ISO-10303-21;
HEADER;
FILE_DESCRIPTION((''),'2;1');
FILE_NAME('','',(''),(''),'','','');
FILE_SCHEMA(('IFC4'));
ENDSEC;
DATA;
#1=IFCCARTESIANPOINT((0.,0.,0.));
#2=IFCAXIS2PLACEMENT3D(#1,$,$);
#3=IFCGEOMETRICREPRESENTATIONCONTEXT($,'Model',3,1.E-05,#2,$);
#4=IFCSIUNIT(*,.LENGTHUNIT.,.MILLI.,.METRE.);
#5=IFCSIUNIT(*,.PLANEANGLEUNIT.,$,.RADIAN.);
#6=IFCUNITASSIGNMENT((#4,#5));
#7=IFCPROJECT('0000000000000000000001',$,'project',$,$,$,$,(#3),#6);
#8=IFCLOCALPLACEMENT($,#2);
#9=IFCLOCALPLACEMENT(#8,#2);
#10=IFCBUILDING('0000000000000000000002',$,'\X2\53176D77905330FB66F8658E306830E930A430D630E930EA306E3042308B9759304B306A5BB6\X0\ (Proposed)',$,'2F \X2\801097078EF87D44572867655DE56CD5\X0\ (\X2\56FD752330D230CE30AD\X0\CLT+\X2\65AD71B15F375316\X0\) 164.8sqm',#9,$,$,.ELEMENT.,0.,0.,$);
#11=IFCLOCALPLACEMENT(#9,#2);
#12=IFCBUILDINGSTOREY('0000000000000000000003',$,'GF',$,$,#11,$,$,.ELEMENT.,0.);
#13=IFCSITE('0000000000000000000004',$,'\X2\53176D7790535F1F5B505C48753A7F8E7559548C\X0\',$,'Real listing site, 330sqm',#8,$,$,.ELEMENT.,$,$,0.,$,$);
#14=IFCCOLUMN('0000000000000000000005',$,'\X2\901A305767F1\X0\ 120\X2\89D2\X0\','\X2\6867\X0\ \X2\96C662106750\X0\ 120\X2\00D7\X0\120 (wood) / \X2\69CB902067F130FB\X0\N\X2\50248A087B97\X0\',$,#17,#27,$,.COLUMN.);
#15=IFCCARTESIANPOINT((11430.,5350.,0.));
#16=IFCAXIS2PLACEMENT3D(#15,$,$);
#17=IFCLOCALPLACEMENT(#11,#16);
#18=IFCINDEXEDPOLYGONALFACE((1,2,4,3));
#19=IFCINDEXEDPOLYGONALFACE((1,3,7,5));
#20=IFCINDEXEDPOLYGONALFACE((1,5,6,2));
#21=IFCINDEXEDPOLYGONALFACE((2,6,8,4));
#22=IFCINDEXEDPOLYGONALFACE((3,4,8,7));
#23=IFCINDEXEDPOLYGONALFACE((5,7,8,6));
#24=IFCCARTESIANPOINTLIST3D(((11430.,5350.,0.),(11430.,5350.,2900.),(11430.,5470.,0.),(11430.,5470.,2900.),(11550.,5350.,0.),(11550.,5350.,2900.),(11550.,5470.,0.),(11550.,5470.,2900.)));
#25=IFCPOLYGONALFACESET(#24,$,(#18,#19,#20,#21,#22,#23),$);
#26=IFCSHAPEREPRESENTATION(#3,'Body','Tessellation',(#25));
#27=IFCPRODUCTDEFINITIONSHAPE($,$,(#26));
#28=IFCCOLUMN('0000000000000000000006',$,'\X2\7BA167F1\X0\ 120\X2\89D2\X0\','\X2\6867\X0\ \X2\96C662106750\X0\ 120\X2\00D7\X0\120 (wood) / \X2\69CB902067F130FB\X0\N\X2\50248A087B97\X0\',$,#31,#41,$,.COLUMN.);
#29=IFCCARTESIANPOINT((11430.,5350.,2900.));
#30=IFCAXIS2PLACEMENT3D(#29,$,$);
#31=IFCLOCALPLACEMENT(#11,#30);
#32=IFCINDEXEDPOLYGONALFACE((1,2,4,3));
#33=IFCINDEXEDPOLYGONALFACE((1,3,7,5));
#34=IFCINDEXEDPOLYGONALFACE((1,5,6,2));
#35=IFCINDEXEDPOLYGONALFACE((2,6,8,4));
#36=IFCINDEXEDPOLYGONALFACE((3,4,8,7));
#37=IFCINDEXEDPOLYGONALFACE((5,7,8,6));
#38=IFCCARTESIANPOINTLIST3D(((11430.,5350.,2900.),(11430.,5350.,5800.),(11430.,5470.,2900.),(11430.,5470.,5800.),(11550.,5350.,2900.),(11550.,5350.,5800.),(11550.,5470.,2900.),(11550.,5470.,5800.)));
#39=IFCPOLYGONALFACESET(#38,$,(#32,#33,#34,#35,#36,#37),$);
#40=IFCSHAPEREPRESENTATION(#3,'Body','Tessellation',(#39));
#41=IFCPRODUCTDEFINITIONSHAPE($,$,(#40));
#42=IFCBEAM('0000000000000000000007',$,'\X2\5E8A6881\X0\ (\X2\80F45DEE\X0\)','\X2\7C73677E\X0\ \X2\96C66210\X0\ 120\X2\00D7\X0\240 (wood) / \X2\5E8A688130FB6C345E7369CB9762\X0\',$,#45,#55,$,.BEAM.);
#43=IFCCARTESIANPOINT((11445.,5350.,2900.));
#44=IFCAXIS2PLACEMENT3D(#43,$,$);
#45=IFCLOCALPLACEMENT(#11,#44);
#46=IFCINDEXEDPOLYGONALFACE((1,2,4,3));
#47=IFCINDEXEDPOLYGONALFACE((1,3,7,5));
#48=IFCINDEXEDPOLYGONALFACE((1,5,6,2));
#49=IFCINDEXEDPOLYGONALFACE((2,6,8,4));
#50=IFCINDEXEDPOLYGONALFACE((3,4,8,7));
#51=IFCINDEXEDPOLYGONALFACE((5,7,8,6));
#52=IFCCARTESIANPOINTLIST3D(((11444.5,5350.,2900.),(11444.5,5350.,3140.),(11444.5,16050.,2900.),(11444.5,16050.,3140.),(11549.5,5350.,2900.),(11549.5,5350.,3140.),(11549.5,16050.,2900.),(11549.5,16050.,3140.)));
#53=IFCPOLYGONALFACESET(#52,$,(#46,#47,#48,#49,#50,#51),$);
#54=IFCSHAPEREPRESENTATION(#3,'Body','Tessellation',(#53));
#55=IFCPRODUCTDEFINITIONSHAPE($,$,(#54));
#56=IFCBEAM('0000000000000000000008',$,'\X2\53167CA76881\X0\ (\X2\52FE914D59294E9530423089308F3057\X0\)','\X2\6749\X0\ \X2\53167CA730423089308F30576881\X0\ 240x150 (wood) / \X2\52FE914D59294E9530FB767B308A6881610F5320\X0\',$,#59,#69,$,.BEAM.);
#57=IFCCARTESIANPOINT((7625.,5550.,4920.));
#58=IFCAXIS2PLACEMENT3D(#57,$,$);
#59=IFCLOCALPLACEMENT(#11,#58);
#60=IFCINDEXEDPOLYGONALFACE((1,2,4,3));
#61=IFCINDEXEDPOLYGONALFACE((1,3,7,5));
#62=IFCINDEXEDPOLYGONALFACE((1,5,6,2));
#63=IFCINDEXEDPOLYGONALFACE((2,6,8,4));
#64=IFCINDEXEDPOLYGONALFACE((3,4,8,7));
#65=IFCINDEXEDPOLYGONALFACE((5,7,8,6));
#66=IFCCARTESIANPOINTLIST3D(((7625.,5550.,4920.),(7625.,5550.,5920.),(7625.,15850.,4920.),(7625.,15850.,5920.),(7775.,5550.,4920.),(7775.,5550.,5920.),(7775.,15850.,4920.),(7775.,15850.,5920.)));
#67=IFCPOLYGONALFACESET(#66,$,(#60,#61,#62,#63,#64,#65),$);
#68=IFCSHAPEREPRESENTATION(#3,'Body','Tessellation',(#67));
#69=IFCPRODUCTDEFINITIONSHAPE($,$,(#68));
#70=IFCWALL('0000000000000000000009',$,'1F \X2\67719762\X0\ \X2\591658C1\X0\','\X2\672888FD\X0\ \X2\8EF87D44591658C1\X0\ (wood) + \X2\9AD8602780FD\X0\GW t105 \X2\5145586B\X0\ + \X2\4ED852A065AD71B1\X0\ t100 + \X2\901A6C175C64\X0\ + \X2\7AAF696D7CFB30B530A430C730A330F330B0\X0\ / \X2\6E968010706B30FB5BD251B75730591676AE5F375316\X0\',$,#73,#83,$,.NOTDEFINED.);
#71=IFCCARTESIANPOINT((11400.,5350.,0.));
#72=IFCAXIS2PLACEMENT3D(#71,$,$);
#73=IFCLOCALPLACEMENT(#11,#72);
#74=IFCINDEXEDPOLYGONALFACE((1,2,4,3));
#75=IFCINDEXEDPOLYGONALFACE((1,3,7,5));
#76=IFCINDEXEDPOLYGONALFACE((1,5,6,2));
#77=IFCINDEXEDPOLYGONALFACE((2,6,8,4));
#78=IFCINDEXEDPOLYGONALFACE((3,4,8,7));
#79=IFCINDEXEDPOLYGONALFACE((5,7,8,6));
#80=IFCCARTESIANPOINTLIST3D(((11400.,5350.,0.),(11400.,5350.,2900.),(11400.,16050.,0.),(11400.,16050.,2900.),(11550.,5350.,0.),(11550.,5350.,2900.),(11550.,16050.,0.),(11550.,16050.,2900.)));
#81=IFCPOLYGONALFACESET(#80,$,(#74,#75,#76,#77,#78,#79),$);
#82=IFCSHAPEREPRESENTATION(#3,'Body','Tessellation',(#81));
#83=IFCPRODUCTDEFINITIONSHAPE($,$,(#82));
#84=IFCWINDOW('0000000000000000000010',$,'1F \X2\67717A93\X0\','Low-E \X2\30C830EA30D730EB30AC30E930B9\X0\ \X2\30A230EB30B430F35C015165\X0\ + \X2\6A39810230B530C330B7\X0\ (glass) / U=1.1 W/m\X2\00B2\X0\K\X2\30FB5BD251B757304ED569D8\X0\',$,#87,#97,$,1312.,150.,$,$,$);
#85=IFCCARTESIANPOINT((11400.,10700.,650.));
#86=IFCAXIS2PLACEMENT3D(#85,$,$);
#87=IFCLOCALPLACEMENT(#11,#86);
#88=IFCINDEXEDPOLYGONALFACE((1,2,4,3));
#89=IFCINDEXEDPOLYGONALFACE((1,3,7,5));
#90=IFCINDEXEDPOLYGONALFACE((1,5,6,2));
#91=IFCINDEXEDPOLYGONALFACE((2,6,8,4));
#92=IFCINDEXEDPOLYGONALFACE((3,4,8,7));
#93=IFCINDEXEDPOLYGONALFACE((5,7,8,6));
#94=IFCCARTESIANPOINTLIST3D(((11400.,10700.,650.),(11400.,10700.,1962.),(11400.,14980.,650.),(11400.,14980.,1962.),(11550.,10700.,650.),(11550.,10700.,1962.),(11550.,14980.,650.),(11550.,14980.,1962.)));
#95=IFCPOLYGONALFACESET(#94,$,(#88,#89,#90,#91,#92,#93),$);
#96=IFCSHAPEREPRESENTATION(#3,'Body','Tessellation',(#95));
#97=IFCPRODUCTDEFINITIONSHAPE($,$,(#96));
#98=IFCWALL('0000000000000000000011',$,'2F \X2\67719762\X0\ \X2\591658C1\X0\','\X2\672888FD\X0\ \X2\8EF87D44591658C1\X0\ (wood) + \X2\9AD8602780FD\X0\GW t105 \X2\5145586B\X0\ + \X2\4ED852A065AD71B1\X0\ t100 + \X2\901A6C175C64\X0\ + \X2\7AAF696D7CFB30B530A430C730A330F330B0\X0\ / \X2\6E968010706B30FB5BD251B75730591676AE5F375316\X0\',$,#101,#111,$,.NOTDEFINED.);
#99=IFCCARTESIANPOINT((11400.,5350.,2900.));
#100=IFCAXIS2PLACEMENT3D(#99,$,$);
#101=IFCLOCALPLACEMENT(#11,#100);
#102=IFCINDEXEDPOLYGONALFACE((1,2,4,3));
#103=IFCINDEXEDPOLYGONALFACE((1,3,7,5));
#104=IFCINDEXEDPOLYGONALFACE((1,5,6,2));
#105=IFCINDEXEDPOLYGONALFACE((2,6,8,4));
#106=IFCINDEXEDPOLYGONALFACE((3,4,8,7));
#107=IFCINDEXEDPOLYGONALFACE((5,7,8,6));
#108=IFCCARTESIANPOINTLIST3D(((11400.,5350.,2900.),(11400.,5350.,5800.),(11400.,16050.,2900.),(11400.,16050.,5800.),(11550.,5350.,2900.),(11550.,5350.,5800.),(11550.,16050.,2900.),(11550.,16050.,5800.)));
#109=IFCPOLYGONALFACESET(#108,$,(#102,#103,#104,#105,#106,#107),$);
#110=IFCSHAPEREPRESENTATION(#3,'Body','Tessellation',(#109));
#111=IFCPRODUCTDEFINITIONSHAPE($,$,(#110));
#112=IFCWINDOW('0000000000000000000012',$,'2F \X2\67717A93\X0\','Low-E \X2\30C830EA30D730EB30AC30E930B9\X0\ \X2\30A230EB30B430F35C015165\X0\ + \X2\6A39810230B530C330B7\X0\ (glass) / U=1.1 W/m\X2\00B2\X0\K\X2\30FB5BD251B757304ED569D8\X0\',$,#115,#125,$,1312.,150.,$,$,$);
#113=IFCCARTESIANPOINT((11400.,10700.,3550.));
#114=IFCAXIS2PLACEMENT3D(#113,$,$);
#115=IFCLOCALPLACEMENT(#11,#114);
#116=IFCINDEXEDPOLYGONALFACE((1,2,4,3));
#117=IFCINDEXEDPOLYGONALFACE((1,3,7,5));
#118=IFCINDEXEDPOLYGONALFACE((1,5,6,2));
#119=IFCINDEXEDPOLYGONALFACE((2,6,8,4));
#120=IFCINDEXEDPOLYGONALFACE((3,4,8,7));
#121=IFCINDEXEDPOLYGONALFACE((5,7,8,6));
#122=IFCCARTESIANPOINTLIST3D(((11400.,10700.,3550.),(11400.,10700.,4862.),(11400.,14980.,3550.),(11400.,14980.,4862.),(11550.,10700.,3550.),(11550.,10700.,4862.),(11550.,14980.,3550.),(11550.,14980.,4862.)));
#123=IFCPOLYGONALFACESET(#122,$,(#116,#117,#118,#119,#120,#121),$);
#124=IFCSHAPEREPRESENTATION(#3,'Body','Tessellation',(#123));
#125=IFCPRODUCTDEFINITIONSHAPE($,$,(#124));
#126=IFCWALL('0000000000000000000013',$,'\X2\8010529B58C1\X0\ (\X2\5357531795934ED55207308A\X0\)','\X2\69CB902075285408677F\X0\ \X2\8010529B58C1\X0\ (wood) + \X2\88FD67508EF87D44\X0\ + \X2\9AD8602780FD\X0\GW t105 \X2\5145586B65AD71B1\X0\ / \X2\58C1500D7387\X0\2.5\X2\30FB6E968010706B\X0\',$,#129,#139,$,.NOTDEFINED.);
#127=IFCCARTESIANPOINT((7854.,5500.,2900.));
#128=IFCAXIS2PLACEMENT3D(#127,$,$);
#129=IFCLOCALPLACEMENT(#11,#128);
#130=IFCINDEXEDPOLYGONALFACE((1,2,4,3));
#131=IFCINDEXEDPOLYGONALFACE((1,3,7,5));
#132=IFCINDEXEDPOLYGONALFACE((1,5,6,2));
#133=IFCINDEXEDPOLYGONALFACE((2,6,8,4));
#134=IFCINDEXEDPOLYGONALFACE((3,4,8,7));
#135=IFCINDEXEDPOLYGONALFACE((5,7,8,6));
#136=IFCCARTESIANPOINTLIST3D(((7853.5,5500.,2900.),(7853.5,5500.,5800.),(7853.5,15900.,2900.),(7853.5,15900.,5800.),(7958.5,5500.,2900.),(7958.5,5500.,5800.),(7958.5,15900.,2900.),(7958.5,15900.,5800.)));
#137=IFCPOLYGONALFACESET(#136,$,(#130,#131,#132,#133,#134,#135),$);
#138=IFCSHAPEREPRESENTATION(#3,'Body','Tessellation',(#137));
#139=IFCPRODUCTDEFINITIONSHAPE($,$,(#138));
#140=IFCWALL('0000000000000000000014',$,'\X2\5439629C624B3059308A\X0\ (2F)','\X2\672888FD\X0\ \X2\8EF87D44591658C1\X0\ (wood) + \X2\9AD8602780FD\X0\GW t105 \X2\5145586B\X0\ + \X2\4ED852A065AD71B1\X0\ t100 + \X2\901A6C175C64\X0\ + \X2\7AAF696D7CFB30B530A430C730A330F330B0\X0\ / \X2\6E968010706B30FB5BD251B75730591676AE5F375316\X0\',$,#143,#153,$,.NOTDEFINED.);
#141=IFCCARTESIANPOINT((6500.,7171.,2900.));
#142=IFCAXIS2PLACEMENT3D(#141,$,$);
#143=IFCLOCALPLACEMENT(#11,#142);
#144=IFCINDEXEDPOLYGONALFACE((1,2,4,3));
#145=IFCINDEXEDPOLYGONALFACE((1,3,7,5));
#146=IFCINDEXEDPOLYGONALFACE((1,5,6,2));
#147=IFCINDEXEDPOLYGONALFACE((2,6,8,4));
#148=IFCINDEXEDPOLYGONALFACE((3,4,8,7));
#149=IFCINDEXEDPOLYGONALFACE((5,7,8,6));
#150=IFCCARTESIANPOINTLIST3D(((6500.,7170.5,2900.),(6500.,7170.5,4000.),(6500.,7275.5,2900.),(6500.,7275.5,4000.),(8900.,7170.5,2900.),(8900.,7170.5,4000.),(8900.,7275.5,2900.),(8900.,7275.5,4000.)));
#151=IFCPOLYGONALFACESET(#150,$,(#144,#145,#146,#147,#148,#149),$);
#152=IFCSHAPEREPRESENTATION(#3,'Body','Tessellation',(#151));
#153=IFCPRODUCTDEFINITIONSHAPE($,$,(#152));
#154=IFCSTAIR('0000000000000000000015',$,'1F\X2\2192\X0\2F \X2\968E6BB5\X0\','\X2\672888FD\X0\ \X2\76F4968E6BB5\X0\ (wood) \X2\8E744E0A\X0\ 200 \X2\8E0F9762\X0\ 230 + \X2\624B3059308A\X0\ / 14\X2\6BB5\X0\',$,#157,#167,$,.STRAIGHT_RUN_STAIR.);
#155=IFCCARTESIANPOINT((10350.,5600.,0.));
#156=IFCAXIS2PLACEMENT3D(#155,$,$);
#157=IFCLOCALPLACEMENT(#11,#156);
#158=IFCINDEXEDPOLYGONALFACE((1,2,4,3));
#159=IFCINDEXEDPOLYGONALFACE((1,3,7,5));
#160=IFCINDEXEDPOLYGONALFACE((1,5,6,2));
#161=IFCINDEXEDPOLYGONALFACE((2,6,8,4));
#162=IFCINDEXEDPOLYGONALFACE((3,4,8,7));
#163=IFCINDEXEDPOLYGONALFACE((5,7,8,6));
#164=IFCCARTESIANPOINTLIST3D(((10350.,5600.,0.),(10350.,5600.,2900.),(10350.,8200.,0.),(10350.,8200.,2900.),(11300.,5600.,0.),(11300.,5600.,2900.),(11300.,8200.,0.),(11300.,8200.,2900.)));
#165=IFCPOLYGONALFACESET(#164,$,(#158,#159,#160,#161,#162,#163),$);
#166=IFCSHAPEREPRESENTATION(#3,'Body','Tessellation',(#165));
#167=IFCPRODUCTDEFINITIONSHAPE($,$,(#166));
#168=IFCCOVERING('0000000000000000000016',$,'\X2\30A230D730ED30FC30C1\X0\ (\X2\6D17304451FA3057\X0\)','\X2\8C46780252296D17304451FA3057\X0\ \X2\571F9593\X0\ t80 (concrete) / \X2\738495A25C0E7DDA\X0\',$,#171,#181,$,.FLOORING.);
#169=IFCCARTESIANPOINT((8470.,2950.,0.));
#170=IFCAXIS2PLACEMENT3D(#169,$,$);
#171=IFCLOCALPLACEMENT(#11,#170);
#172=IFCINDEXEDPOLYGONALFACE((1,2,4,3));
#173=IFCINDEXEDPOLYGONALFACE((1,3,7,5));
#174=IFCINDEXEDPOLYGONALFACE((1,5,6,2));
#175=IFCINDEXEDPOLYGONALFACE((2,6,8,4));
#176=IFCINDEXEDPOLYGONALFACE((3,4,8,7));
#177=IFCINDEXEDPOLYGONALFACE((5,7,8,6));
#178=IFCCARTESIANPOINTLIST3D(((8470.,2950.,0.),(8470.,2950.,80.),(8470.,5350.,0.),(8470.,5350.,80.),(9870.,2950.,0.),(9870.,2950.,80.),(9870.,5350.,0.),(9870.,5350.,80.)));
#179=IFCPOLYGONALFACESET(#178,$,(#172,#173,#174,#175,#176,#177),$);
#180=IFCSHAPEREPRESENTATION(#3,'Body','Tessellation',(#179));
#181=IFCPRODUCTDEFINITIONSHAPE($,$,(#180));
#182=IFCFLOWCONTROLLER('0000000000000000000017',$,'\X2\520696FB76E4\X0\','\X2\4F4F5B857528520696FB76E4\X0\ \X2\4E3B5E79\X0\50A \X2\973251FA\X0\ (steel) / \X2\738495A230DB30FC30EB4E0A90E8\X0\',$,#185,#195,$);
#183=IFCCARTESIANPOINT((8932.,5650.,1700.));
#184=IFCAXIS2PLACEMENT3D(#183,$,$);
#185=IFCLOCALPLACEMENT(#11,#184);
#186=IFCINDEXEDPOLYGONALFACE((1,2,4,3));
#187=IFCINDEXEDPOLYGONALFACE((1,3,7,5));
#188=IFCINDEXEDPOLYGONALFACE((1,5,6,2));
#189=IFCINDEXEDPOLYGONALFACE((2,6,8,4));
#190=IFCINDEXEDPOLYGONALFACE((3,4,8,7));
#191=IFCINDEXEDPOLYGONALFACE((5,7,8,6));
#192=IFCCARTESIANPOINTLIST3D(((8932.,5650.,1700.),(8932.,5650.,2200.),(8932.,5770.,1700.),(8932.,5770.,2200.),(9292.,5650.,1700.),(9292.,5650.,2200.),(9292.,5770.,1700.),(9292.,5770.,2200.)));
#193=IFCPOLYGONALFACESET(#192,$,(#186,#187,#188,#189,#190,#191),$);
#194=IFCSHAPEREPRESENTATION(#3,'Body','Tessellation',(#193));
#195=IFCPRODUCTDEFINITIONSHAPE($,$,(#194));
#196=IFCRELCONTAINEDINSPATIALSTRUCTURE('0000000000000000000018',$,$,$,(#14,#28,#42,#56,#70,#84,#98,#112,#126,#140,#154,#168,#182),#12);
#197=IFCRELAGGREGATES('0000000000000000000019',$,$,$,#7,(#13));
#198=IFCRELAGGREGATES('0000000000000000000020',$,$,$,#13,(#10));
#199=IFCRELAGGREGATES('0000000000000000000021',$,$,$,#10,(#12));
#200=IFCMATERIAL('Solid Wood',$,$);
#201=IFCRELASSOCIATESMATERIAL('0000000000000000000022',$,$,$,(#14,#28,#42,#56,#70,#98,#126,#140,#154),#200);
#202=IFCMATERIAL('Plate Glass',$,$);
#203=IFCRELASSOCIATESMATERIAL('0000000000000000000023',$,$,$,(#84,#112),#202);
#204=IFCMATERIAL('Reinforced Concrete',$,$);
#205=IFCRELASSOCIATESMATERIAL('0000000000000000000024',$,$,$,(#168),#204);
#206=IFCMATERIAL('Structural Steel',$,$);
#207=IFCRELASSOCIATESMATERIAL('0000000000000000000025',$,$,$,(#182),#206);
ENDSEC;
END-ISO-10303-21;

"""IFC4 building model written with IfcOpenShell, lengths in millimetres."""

from ifc_helpers import new_model, si_unit, frame, frame_2d, origin, place, context, project, spatial, rectangle, extrude, material, element, fill, save


model = new_model("IFC4")

# Units and contexts
model_context = context("Model", 3, precision=1e-05, world=origin())
ifc_project = project(units=[si_unit("LENGTHUNIT", "METRE", prefix="MILLI"), si_unit("PLANEANGLEUNIT", "RADIAN")], contexts=[model_context])

# Site, building, storey
site_placement = place(None, origin())
site = spatial("IfcSite", under=ifc_project, at=site_placement, Name="北海道弟子屈町美留和", ObjectType="Real listing site, 330sqm", CompositionType="ELEMENT", RefElevation=0.0)
building_placement = place(site_placement, origin())
building = spatial("IfcBuilding", under=site, at=building_placement, Name="北海道・書斎とライブラリのある静かな家 (Proposed)", ObjectType="2F 耐震軸組在来工法 (国産ヒノキCLT+断熱強化) 164.8sqm", CompositionType="ELEMENT", ElevationOfRefHeight=0.0, ElevationOfTerrain=0.0)
storey_placement = place(building_placement, origin())
storey = spatial("IfcBuildingStorey", under=building, at=storey_placement, Name="GF", CompositionType="ELEMENT", Elevation=0.0)

# Columns
ifc_material_1 = material(Name="Solid Wood")
column_1_placement = place(storey_placement, frame((11430.0, 5350.0, 0.0)))
element("IfcColumn", 1, at=column_1_placement, inside=storey, material=ifc_material_1, Name="通し柱 120角", Description="桧 集成材 120×120 (wood) / 構造柱・N値計算", PredefinedType="COLUMN", context=model_context, shape_type="SweptSolid", body=[
    extrude(rectangle(XDim=120.0, YDim=120.0, at=frame_2d((60.0, 60.0))), frame((11430.0, 5350.0, 0.0)), (0.0, 0.0, 1.0), 2900.0),
])
column_2_placement = place(storey_placement, frame((11430.0, 5350.0, 2900.0)))
element("IfcColumn", 2, at=column_2_placement, inside=storey, material=ifc_material_1, Name="管柱 120角", Description="桧 集成材 120×120 (wood) / 構造柱・N値計算", PredefinedType="COLUMN", context=model_context, shape_type="SweptSolid", body=[
    extrude(rectangle(XDim=120.0, YDim=120.0, at=frame_2d((60.0, 60.0))), frame((11430.0, 5350.0, 2900.0)), (0.0, 0.0, 1.0), 2900.0),
])

# Beams
beam_1_placement = place(storey_placement, frame((11445.0, 5350.0, 2900.0)))
element("IfcBeam", 3, at=beam_1_placement, inside=storey, material=ifc_material_1, Name="床梁 (胴差)", Description="米松 集成 120×240 (wood) / 床梁・水平構面", PredefinedType="BEAM", context=model_context, shape_type="SweptSolid", body=[
    extrude(rectangle(XDim=105.0, YDim=10700.0, at=frame_2d((52.0, 5350.0))), frame((11445.0, 5350.0, 2900.0)), (0.0, 0.0, 1.0), 240.0),
])
beam_2_placement = place(storey_placement, frame((7625.0, 5550.0, 4920.0)))
element("IfcBeam", 4, at=beam_2_placement, inside=storey, material=ifc_material_1, Name="化粧梁 (勾配天井あらわし)", Description="杉 化粧あらわし梁 240x150 (wood) / 勾配天井・登り梁意匠", PredefinedType="BEAM", context=model_context, shape_type="SweptSolid", body=[
    extrude(rectangle(XDim=150.0, YDim=10300.0, at=frame_2d((75.0, 5150.0))), frame((7625.0, 5550.0, 4920.0)), (0.0, 0.0, 1.0), 1000.0),
])

# Wall, opening, window
wall_1_placement = place(storey_placement, frame((11400.0, 5350.0, 0.0)))
wall_1 = element("IfcWall", 5, at=wall_1_placement, inside=storey, material=ifc_material_1, Name="1F 東面 外壁", Description="木製 軸組外壁 (wood) + 高性能GW t105 充填 + 付加断熱 t100 + 通気層 + 窯業系サイディング / 準耐火・寒冷地外皮強化", PredefinedType="NOTDEFINED", context=model_context, shape_type="SweptSolid", body=[
    extrude(rectangle(XDim=150.0, YDim=10700.0, at=frame_2d((75.0, 5350.0))), frame((11400.0, 5350.0, 0.0)), (0.0, 0.0, 1.0), 2900.0),
])
opening_1_placement = place(storey_placement, frame((11400.0, 10700.0, 650.0)))
opening_1 = element("IfcOpeningElement", 6, at=opening_1_placement, cuts=wall_1, PredefinedType="NOTDEFINED", context=model_context, shape_type="SweptSolid", body=[
    extrude(rectangle(XDim=150.0, YDim=4280.0, at=frame_2d((75.0, 2140.0))), frame((11400.0, 10700.0, 650.0)), (0.0, 0.0, 1.0), 1312.0),
])
ifc_material_2 = material(Name="Plate Glass")
window_1_placement = place(storey_placement, frame((11400.0, 10700.0, 650.0)))
window_1 = element("IfcWindow", 7, at=window_1_placement, inside=storey, material=ifc_material_2, Name="1F 東窓", Description="Low-E トリプルガラス アルゴン封入 + 樹脂サッシ (glass) / U=1.1 W/m²K・寒冷地仕様", OverallHeight=1312.0, OverallWidth=150.0, context=model_context, shape_type="SweptSolid", body=[
    extrude(rectangle(XDim=150.0, YDim=4280.0, at=frame_2d((75.0, 2140.0))), frame((11400.0, 10700.0, 650.0)), (0.0, 0.0, 1.0), 1312.0),
])
fill(opening_1, window_1)

# Wall, opening, window
wall_2_placement = place(storey_placement, frame((11400.0, 5350.0, 2900.0)))
wall_2 = element("IfcWall", 8, at=wall_2_placement, inside=storey, material=ifc_material_1, Name="2F 東面 外壁", Description="木製 軸組外壁 (wood) + 高性能GW t105 充填 + 付加断熱 t100 + 通気層 + 窯業系サイディング / 準耐火・寒冷地外皮強化", PredefinedType="NOTDEFINED", context=model_context, shape_type="SweptSolid", body=[
    extrude(rectangle(XDim=150.0, YDim=10700.0, at=frame_2d((75.0, 5350.0))), frame((11400.0, 5350.0, 2900.0)), (0.0, 0.0, 1.0), 2900.0),
])
opening_2_placement = place(storey_placement, frame((11400.0, 10700.0, 3550.0)))
opening_2 = element("IfcOpeningElement", 9, at=opening_2_placement, cuts=wall_2, PredefinedType="NOTDEFINED", context=model_context, shape_type="SweptSolid", body=[
    extrude(rectangle(XDim=150.0, YDim=4280.0, at=frame_2d((75.0, 2140.0))), frame((11400.0, 10700.0, 3550.0)), (0.0, 0.0, 1.0), 1312.0),
])
window_2_placement = place(storey_placement, frame((11400.0, 10700.0, 3550.0)))
window_2 = element("IfcWindow", 10, at=window_2_placement, inside=storey, material=ifc_material_2, Name="2F 東窓", Description="Low-E トリプルガラス アルゴン封入 + 樹脂サッシ (glass) / U=1.1 W/m²K・寒冷地仕様", OverallHeight=1312.0, OverallWidth=150.0, context=model_context, shape_type="SweptSolid", body=[
    extrude(rectangle(XDim=150.0, YDim=4280.0, at=frame_2d((75.0, 2140.0))), frame((11400.0, 10700.0, 3550.0)), (0.0, 0.0, 1.0), 1312.0),
])
fill(opening_2, window_2)

# Walls
wall_3_placement = place(storey_placement, frame((7854.0, 5500.0, 2900.0)))
element("IfcWall", 11, at=wall_3_placement, inside=storey, material=ifc_material_1, Name="耐力壁 (南北間仕切り)", Description="構造用合板 耐力壁 (wood) + 製材軸組 + 高性能GW t105 充填断熱 / 壁倍率2.5・準耐火", PredefinedType="NOTDEFINED", context=model_context, shape_type="SweptSolid", body=[
    extrude(rectangle(XDim=105.0, YDim=10400.0, at=frame_2d((52.0, 5200.0))), frame((7854.0, 5500.0, 2900.0)), (0.0, 0.0, 1.0), 2900.0),
])
wall_4_placement = place(storey_placement, frame((6500.0, 7171.0, 2900.0)))
element("IfcWall", 12, at=wall_4_placement, inside=storey, material=ifc_material_1, Name="吹抜手すり (2F)", Description="木製 軸組外壁 (wood) + 高性能GW t105 充填 + 付加断熱 t100 + 通気層 + 窯業系サイディング / 準耐火・寒冷地外皮強化", PredefinedType="NOTDEFINED", context=model_context, shape_type="SweptSolid", body=[
    extrude(rectangle(XDim=2400.0, YDim=105.0, at=frame_2d((1200.0, 52.0))), frame((6500.0, 7171.0, 2900.0)), (0.0, 0.0, 1.0), 1100.0),
])

# Stair
stair_placement = place(storey_placement, frame((10350.0, 5600.0, 0.0)))
element("IfcStair", 13, at=stair_placement, inside=storey, material=ifc_material_1, Name="1F→2F 階段", Description="木製 直階段 (wood) 蹴上 200 踏面 230 + 手すり / 14段", PredefinedType="STRAIGHT_RUN_STAIR", context=model_context, shape_type="SweptSolid", body=[
    extrude(rectangle(XDim=950.0, YDim=2600.0, at=frame_2d((475.0, 1300.0))), frame((10350.0, 5600.0, 0.0)), (0.0, 0.0, 1.0), 2900.0),
])

# Covering
ifc_material_3 = material(Name="Reinforced Concrete")
covering_placement = place(storey_placement, frame((8470.0, 2950.0, 0.0)))
element("IfcCovering", 14, at=covering_placement, inside=storey, material=ifc_material_3, Name="アプローチ (洗い出し)", Description="豆砂利洗い出し 土間 t80 (concrete) / 玄関導線", PredefinedType="FLOORING", context=model_context, shape_type="SweptSolid", body=[
    extrude(rectangle(XDim=1400.0, YDim=2400.0, at=frame_2d((700.0, 1200.0))), frame((8470.0, 2950.0, 0.0)), (0.0, 0.0, 1.0), 80.0),
])

# Flow controller
ifc_material_4 = material(Name="Structural Steel")
flow_controller_placement = place(storey_placement, frame((8932.0, 5650.0, 1700.0)))
element("IfcFlowController", 15, at=flow_controller_placement, inside=storey, material=ifc_material_4, Name="分電盤", Description="住宅用分電盤 主幹50A 露出 (steel) / 玄関ホール上部", context=model_context, shape_type="SweptSolid", body=[
    extrude(rectangle(XDim=360.0, YDim=120.0, at=frame_2d((180.0, 60.0))), frame((8932.0, 5650.0, 1700.0)), (0.0, 0.0, 1.0), 500.0),
])

save(model, "model.ifc")
